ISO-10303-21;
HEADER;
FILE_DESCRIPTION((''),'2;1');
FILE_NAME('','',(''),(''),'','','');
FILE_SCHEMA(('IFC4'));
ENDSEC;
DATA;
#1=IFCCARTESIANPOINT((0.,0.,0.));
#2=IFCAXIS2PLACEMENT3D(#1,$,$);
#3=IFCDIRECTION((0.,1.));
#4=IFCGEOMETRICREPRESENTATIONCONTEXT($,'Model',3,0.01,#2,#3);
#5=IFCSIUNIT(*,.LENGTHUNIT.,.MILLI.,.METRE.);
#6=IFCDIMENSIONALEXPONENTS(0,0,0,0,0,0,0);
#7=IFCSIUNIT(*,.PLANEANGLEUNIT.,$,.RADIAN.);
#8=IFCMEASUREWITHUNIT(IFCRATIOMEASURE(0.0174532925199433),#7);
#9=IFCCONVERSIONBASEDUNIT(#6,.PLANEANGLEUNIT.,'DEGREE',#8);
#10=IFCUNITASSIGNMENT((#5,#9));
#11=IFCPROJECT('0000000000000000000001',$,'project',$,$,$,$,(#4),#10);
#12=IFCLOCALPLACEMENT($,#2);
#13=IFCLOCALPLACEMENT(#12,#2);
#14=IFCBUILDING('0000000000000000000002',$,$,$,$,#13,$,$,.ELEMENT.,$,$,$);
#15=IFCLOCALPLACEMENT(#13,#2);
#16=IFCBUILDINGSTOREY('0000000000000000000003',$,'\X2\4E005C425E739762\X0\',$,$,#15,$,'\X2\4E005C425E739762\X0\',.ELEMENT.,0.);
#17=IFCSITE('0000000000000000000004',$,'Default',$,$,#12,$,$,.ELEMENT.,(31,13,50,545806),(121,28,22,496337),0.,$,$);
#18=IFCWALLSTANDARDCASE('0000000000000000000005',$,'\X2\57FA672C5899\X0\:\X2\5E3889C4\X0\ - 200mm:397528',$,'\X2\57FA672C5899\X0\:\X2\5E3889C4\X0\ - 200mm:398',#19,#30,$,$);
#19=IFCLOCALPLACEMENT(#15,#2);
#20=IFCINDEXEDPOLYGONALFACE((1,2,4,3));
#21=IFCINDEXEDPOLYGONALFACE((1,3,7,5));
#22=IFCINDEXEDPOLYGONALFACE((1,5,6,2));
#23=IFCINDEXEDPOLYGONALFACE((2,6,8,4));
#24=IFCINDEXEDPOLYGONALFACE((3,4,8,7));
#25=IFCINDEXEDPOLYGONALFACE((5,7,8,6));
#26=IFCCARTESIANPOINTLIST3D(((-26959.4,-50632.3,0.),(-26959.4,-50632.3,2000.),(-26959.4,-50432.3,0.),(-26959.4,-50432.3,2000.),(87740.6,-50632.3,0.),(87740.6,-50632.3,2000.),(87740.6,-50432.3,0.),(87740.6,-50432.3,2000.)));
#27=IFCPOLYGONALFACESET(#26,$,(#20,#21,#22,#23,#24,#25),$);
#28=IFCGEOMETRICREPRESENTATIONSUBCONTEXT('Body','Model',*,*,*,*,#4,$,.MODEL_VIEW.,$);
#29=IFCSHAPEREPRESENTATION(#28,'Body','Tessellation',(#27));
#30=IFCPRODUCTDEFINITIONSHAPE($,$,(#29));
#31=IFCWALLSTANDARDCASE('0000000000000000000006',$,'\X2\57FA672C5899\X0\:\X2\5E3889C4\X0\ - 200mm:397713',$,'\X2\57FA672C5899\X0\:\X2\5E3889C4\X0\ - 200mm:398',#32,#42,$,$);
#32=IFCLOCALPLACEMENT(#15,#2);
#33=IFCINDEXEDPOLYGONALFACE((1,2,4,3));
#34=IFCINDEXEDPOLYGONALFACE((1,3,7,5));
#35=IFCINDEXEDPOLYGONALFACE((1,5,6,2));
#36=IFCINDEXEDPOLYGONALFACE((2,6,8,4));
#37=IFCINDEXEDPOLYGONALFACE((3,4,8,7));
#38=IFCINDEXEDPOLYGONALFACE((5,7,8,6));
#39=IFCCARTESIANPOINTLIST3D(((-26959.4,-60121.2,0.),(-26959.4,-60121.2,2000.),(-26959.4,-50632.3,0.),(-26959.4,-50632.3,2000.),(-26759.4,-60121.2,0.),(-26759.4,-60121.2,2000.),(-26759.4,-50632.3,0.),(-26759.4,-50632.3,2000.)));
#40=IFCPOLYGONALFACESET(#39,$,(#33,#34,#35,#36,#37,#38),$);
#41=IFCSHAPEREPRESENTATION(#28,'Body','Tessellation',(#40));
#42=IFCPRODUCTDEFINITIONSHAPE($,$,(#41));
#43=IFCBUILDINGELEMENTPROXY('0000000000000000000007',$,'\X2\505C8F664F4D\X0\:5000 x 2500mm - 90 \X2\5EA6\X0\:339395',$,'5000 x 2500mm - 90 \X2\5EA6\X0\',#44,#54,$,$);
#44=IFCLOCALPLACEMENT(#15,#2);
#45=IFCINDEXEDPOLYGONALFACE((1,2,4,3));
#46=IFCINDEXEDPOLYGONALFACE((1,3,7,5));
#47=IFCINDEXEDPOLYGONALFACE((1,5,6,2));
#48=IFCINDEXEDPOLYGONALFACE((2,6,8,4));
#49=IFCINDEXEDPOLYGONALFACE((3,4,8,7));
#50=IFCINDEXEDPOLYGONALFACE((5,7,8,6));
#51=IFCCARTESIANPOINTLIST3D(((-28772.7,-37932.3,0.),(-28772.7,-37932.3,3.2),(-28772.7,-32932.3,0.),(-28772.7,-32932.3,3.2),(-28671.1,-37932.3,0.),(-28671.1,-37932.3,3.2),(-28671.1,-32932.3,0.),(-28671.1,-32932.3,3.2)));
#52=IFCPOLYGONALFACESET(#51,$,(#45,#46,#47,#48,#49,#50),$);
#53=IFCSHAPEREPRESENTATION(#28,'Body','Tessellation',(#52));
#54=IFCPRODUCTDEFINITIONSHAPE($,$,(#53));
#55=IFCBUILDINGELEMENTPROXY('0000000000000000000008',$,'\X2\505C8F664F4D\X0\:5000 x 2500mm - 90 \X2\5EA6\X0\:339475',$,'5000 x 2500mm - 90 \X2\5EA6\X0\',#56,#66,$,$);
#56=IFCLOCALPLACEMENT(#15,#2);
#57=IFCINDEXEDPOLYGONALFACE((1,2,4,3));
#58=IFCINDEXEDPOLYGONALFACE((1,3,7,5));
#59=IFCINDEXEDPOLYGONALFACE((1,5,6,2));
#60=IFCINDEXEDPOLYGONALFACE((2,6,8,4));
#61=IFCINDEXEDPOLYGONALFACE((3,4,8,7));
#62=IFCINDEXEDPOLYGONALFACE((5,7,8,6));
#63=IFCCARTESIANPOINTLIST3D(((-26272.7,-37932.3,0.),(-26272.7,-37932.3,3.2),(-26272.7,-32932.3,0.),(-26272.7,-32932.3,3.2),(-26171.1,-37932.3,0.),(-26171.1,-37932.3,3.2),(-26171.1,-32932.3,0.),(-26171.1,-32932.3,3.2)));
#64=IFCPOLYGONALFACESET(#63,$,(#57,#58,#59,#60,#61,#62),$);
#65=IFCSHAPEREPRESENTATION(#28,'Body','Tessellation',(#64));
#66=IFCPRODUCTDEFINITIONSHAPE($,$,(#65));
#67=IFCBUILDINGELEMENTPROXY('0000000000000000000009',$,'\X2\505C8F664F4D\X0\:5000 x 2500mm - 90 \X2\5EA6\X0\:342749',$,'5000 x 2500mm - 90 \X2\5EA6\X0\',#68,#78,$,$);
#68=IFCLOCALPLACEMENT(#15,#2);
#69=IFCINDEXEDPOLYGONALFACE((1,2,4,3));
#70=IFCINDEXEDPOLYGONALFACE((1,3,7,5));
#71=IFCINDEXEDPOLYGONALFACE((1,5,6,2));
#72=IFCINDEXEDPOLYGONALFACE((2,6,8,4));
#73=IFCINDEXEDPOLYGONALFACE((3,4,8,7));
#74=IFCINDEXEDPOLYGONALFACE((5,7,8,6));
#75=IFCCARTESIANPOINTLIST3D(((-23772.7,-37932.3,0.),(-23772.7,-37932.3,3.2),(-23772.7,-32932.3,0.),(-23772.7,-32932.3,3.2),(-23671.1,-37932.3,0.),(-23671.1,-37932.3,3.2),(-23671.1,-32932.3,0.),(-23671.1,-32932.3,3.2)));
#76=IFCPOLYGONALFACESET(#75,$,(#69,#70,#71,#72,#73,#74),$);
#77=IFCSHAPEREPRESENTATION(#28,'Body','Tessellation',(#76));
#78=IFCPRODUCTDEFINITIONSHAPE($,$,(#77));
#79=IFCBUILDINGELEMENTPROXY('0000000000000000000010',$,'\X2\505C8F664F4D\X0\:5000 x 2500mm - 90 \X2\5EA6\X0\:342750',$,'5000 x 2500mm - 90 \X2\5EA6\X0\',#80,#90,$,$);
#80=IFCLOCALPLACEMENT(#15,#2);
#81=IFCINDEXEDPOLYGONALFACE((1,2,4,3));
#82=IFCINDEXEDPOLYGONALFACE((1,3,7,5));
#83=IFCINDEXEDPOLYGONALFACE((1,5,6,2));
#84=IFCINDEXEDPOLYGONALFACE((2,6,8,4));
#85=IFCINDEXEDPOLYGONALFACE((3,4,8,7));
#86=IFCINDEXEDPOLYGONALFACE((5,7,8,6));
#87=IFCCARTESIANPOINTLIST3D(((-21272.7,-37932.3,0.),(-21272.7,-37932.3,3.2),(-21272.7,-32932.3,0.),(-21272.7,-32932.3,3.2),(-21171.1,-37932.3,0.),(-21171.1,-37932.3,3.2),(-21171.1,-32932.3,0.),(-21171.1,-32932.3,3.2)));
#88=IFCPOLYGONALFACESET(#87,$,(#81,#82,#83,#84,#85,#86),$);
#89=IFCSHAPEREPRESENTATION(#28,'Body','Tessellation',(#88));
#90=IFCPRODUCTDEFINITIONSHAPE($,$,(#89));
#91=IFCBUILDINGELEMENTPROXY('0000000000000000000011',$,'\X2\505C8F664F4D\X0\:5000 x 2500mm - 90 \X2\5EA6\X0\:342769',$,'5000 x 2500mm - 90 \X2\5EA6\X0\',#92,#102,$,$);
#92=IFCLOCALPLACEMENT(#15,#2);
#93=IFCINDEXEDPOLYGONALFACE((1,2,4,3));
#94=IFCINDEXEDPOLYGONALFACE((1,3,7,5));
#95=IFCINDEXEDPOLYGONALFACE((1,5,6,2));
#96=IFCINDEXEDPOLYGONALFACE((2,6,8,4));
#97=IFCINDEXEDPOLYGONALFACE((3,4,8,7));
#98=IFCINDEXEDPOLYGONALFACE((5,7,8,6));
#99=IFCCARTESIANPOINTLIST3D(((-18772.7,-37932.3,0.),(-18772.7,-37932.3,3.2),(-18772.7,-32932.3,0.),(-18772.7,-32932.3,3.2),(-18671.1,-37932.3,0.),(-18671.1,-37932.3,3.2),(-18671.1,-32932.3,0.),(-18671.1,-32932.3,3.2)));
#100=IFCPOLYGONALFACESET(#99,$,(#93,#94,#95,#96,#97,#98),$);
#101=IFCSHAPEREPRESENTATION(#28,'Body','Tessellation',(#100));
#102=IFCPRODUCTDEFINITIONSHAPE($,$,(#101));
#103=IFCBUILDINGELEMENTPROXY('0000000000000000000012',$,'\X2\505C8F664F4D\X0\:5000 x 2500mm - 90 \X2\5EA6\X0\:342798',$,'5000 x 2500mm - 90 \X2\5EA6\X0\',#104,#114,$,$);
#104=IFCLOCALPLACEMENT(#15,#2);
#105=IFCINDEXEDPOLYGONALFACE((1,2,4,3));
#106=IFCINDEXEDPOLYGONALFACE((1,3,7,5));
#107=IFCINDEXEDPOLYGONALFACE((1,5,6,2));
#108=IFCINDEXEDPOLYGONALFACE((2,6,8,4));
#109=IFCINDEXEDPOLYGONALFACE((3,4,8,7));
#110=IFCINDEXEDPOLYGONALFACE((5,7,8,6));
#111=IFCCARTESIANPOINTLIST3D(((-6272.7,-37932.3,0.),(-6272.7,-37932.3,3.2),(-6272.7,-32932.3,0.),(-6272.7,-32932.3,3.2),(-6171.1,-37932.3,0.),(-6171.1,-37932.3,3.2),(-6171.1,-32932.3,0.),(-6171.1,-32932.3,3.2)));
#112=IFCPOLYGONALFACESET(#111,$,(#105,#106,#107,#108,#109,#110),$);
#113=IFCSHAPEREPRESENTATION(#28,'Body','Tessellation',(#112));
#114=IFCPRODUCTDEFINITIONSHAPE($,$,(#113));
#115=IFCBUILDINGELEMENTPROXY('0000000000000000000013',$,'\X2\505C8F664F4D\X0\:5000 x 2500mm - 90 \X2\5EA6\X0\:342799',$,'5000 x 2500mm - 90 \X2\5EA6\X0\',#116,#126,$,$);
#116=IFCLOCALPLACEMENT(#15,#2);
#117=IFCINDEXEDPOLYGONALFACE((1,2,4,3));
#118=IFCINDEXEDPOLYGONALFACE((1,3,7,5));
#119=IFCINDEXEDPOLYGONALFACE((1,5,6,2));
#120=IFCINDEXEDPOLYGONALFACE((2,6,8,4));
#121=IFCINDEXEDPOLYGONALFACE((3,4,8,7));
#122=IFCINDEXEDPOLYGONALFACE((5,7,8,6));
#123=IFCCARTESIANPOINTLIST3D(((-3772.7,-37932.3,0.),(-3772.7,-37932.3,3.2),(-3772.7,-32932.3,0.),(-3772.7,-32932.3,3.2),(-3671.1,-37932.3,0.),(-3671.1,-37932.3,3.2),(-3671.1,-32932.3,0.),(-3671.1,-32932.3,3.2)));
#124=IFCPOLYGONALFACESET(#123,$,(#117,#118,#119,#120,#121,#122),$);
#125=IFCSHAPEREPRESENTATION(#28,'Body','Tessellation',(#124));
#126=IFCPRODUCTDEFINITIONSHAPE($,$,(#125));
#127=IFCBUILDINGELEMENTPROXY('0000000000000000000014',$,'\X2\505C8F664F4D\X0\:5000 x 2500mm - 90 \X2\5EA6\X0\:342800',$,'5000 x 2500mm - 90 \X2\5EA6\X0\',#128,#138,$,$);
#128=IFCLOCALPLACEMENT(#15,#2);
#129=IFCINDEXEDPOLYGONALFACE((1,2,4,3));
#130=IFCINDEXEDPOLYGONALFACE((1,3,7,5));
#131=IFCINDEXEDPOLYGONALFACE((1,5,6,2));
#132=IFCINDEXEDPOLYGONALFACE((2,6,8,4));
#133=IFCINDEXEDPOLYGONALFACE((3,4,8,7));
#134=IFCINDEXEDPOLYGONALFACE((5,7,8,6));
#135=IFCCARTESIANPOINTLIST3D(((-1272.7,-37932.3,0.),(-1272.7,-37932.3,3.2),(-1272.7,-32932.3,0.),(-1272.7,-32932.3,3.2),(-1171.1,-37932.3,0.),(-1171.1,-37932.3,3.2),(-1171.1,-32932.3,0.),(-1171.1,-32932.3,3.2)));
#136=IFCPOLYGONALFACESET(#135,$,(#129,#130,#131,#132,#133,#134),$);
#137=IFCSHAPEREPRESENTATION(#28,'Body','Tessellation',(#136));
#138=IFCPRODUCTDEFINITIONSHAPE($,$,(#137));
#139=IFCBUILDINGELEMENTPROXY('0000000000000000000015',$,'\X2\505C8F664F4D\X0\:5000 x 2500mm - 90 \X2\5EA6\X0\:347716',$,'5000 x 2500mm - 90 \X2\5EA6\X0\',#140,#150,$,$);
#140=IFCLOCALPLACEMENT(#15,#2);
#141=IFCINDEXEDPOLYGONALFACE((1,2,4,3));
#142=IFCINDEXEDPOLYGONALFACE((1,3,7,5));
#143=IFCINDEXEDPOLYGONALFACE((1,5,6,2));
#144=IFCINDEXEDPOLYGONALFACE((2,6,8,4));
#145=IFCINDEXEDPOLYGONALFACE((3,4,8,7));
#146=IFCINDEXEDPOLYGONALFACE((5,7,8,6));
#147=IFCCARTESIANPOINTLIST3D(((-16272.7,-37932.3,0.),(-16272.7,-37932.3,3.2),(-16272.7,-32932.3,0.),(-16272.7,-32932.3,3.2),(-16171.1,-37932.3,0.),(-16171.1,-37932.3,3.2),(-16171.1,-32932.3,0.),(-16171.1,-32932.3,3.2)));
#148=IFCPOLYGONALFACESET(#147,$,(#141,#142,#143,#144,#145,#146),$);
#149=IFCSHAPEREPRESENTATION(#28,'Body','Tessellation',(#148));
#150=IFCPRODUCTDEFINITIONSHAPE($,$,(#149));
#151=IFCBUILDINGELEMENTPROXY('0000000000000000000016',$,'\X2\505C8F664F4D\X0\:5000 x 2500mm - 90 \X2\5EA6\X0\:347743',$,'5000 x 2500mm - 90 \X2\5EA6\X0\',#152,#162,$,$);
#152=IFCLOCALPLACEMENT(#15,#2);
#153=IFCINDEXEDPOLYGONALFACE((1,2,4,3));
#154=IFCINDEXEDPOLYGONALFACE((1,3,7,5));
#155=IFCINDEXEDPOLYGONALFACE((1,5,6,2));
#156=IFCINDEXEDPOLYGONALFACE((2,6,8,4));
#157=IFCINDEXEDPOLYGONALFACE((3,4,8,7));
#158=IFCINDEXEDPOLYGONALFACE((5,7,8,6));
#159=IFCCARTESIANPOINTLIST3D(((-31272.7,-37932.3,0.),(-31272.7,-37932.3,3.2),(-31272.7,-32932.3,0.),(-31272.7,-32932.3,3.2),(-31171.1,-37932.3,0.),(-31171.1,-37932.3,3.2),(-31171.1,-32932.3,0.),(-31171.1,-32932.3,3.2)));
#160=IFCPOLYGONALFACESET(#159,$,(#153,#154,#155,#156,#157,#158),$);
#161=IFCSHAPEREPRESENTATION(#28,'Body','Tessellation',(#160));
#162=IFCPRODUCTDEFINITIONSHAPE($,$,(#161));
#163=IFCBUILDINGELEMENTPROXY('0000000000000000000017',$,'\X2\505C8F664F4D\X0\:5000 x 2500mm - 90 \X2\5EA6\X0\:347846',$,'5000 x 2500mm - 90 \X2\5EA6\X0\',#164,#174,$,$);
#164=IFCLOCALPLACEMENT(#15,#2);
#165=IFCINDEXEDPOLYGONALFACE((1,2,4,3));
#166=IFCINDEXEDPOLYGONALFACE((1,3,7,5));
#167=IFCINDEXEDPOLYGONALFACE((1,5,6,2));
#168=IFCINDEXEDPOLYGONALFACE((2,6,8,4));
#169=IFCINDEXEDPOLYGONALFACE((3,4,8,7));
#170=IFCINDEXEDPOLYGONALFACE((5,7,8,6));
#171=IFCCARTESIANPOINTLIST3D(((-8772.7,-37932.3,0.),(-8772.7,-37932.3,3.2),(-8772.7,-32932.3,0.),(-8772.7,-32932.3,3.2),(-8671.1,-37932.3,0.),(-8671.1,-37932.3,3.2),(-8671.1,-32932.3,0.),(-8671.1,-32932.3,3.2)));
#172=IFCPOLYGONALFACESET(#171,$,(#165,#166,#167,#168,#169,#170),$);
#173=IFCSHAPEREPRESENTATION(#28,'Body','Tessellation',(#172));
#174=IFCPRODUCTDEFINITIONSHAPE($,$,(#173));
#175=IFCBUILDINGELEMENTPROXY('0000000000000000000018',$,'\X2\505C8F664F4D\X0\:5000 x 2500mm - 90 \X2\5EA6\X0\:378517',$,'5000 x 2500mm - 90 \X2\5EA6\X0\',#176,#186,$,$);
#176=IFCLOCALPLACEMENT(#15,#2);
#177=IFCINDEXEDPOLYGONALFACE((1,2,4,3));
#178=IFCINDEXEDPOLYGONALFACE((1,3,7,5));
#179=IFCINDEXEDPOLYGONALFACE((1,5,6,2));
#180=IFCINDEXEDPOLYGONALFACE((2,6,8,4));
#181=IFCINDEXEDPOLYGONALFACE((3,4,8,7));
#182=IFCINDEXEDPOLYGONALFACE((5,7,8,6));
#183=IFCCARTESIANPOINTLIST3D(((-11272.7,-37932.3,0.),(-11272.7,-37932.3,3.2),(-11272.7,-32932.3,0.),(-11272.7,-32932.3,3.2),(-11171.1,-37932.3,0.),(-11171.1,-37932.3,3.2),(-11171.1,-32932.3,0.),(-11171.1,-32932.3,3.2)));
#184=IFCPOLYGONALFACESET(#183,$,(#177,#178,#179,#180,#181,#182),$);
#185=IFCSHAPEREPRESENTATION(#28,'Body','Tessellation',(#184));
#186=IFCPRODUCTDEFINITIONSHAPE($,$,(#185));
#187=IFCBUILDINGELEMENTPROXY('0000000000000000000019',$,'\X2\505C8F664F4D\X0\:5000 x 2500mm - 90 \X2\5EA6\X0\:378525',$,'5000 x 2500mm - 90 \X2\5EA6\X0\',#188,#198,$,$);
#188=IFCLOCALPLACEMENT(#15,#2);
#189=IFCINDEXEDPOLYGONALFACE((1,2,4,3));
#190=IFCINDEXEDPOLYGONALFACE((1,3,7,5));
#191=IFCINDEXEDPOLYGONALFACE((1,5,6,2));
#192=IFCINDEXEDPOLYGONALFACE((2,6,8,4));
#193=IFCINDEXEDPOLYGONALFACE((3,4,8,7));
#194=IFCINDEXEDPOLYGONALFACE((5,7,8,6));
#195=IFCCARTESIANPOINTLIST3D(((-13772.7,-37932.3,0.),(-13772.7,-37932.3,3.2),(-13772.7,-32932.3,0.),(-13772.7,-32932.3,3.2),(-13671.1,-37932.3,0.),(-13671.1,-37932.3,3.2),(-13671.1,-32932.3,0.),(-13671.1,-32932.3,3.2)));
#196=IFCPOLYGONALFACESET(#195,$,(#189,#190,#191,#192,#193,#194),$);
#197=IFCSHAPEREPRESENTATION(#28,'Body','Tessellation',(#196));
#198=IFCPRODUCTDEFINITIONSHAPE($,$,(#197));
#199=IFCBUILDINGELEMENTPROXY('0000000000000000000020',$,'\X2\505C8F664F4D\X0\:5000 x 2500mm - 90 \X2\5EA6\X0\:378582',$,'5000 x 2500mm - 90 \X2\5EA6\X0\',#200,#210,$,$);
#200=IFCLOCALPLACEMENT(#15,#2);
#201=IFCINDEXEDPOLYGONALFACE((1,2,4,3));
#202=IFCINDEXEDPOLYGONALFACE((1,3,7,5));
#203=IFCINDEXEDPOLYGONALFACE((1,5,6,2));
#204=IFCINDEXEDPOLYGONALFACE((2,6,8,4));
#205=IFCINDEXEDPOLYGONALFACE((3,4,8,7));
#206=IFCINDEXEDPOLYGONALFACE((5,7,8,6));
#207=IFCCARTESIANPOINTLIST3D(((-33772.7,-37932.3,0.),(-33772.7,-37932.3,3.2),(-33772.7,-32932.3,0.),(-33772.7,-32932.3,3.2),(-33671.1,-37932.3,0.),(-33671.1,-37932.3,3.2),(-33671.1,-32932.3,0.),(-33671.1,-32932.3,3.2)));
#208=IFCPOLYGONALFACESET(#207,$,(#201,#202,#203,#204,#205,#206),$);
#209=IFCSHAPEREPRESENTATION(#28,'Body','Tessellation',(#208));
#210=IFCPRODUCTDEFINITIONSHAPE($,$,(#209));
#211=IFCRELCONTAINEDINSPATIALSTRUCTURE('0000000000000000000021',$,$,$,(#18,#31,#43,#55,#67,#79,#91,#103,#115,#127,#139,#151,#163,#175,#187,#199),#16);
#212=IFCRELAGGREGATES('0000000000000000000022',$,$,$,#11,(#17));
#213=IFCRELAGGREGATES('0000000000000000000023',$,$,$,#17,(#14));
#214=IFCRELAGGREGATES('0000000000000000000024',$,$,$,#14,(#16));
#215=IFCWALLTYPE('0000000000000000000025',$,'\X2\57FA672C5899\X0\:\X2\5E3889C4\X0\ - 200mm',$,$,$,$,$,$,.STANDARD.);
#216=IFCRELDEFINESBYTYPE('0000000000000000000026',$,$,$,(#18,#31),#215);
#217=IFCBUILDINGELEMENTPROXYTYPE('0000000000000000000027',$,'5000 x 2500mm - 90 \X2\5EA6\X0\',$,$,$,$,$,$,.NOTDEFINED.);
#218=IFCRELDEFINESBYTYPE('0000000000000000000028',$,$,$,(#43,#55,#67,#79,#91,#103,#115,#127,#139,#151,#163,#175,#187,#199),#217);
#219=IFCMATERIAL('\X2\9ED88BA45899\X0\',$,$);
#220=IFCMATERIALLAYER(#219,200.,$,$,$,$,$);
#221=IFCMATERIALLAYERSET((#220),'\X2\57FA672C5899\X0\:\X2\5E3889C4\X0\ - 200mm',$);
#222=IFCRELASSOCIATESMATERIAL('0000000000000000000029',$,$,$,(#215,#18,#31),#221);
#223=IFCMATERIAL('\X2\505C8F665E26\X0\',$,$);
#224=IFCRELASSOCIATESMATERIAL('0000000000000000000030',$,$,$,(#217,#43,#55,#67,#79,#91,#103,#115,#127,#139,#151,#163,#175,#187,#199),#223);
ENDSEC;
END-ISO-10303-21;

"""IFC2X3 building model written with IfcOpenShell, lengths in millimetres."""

from ifc_helpers import new_model, entity, si_unit, converted_unit, direction, frame, frame_2d, origin, origin_2d_with_axis, place, context, subcontext, project, spatial, rectangle, extrude, source, transform, mapped, material, layer, layer_set, layer_usage, type_object, type_shapes, element, save


model = new_model("IFC2X3")

# Units and contexts
model_context = context("Model", 3, precision=0.01, world=origin(), true_north=direction((0.0, 1.0)))
body_context = subcontext(model_context, "Body", "Model", "MODEL_VIEW")
ifc_project = project(units=[si_unit("LENGTHUNIT", "METRE", prefix="MILLI"), converted_unit("PLANEANGLEUNIT", "DEGREE", entity("IfcRatioMeasure", 0.0174532925199433), si_unit("PLANEANGLEUNIT", "RADIAN"), dimensions=[0, 0, 0, 0, 0, 0, 0])], contexts=[model_context])

# Site, building, storey
site_placement = place(None, origin())
site = spatial("IfcSite", under=ifc_project, at=site_placement, Name="Default", CompositionType="ELEMENT", RefLatitude=(31, 13, 50, 545806), RefLongitude=(121, 28, 22, 496337), RefElevation=0.0)
building_placement = place(site_placement, origin())
building = spatial("IfcBuilding", under=site, at=building_placement, CompositionType="ELEMENT")
storey_placement = place(building_placement, origin())
storey = spatial("IfcBuildingStorey", under=building, at=storey_placement, Name="一层平面", LongName="一层平面", CompositionType="ELEMENT", Elevation=0.0)

# Walls
ifc_material_1 = material(Name="默认墙")
ifc_layer_1 = layer(ifc_material_1, 200.0)
ifc_layer_set_1 = layer_set([ifc_layer_1], Name="基本墙:常规 - 200mm")
ifc_layer_usage_1 = layer_usage(ifc_layer_set_1, "AXIS2", "NEGATIVE", 100.0)
wall_type = type_object("IfcWallType", Name="基本墙:常规 - 200mm", PredefinedType="STANDARD", material=ifc_layer_set_1)
wall_1_placement = place(storey_placement, frame((-26959.4, -50532.3, 0.0)))
element("IfcWallStandardCase", 1, at=wall_1_placement, inside=storey, type_object=wall_type, material=ifc_layer_usage_1, Name="基本墙:常规 - 200mm:397528", ObjectType="基本墙:常规 - 200mm:398", context=body_context, shape_type="SweptSolid", body=[
    extrude(rectangle(XDim=114700.0, YDim=200.0, at=frame_2d((57350.0, 0.0), x_axis=(-1.0, 0.0))), origin(), (0.0, 0.0, 1.0), 2000.0),
])
ifc_layer_usage_2 = layer_usage(ifc_layer_set_1, "AXIS2", "NEGATIVE", 100.0)
wall_2_placement = place(storey_placement, frame((-26859.4, -50632.3, 0.0), z_axis=(0.0, 0.0, 1.0), x_axis=(0.0, -1.0, 0.0)))
element("IfcWallStandardCase", 2, at=wall_2_placement, inside=storey, type_object=wall_type, material=ifc_layer_usage_2, Name="基本墙:常规 - 200mm:397713", ObjectType="基本墙:常规 - 200mm:398", context=body_context, shape_type="SweptSolid", body=[
    extrude(rectangle(XDim=9489.0, YDim=200.0, at=frame_2d((4744.5, 0.0), x_axis=(-1.0, 0.0))), origin(), (0.0, 0.0, 1.0), 2000.0),
])

# Building element proxies
ifc_material_2 = material(Name="停车带")
building_element_proxy_type = type_object("IfcBuildingElementProxyType", Name="5000 x 2500mm - 90 度", PredefinedType="NOTDEFINED", material=ifc_material_2)
shared_shape = source(origin(), body_context, "Body", "SweptSolid", [
    extrude(rectangle(XDim=101.6, YDim=5000.0, at=origin_2d_with_axis()), frame((0.0, 2500.0, 0.0)), (0.0, 0.0, 1.0), 3.2),
])
type_shapes(building_element_proxy_type, [shared_shape])
for number, where, z_axis, x_axis, name in (
    (3, (-28721.9, -32932.3, 0.0), (0.0, 0.0, 1.0), (-1.0, 0.0, 0.0), "停车位:5000 x 2500mm - 90 度:339395"),
    (4, (-26221.9, -32932.3, 0.0), (0.0, 0.0, 1.0), (-1.0, 0.0, 0.0), "停车位:5000 x 2500mm - 90 度:339475"),
    (5, (-23721.9, -32932.3, 0.0), (0.0, 0.0, 1.0), (-1.0, 0.0, 0.0), "停车位:5000 x 2500mm - 90 度:342749"),
    (6, (-21221.9, -32932.3, 0.0), (0.0, 0.0, 1.0), (-1.0, 0.0, 0.0), "停车位:5000 x 2500mm - 90 度:342750"),
    (7, (-18721.9, -32932.3, 0.0), (0.0, 0.0, 1.0), (-1.0, 0.0, 0.0), "停车位:5000 x 2500mm - 90 度:342769"),
    (8, (-6221.9, -32932.3, 0.0), (0.0, 0.0, 1.0), (-1.0, 0.0, 0.0), "停车位:5000 x 2500mm - 90 度:342798"),
    (9, (-3721.9, -32932.3, 0.0), (0.0, 0.0, 1.0), (-1.0, 0.0, 0.0), "停车位:5000 x 2500mm - 90 度:342799"),
    (10, (-1221.9, -32932.3, 0.0), (0.0, 0.0, 1.0), (-1.0, 0.0, 0.0), "停车位:5000 x 2500mm - 90 度:342800"),
    (11, (-16221.9, -32932.3, 0.0), (0.0, 0.0, 1.0), (-1.0, 0.0, 0.0), "停车位:5000 x 2500mm - 90 度:347716"),
    (12, (-31221.9, -32932.3, 0.0), (0.0, 0.0, 1.0), (-1.0, 0.0, 0.0), "停车位:5000 x 2500mm - 90 度:347743"),
    (13, (-8721.9, -32932.3, 0.0), (0.0, 0.0, 1.0), (-1.0, 0.0, 0.0), "停车位:5000 x 2500mm - 90 度:347846"),
    (14, (-11221.9, -32932.3, 0.0), (0.0, 0.0, 1.0), (-1.0, 0.0, 0.0), "停车位:5000 x 2500mm - 90 度:378517"),
    (15, (-13721.9, -32932.3, 0.0), (0.0, 0.0, 1.0), (-1.0, 0.0, 0.0), "停车位:5000 x 2500mm - 90 度:378525"),
    (16, (-33721.9, -32932.3, 0.0), (0.0, 0.0, 1.0), (-1.0, 0.0, 0.0), "停车位:5000 x 2500mm - 90 度:378582"),
):
    element("IfcBuildingElementProxy", number, at=place(storey_placement, frame(where, z_axis=z_axis, x_axis=x_axis)), inside=storey, type_object=building_element_proxy_type, material=ifc_material_2, Name=name, ObjectType="5000 x 2500mm - 90 度", context=body_context, shape_type="MappedRepresentation", body=[
        mapped(shared_shape, transform((0.0, 0.0, 0.0), scale=1.0)),
    ])

save(model, "model.ifc")
